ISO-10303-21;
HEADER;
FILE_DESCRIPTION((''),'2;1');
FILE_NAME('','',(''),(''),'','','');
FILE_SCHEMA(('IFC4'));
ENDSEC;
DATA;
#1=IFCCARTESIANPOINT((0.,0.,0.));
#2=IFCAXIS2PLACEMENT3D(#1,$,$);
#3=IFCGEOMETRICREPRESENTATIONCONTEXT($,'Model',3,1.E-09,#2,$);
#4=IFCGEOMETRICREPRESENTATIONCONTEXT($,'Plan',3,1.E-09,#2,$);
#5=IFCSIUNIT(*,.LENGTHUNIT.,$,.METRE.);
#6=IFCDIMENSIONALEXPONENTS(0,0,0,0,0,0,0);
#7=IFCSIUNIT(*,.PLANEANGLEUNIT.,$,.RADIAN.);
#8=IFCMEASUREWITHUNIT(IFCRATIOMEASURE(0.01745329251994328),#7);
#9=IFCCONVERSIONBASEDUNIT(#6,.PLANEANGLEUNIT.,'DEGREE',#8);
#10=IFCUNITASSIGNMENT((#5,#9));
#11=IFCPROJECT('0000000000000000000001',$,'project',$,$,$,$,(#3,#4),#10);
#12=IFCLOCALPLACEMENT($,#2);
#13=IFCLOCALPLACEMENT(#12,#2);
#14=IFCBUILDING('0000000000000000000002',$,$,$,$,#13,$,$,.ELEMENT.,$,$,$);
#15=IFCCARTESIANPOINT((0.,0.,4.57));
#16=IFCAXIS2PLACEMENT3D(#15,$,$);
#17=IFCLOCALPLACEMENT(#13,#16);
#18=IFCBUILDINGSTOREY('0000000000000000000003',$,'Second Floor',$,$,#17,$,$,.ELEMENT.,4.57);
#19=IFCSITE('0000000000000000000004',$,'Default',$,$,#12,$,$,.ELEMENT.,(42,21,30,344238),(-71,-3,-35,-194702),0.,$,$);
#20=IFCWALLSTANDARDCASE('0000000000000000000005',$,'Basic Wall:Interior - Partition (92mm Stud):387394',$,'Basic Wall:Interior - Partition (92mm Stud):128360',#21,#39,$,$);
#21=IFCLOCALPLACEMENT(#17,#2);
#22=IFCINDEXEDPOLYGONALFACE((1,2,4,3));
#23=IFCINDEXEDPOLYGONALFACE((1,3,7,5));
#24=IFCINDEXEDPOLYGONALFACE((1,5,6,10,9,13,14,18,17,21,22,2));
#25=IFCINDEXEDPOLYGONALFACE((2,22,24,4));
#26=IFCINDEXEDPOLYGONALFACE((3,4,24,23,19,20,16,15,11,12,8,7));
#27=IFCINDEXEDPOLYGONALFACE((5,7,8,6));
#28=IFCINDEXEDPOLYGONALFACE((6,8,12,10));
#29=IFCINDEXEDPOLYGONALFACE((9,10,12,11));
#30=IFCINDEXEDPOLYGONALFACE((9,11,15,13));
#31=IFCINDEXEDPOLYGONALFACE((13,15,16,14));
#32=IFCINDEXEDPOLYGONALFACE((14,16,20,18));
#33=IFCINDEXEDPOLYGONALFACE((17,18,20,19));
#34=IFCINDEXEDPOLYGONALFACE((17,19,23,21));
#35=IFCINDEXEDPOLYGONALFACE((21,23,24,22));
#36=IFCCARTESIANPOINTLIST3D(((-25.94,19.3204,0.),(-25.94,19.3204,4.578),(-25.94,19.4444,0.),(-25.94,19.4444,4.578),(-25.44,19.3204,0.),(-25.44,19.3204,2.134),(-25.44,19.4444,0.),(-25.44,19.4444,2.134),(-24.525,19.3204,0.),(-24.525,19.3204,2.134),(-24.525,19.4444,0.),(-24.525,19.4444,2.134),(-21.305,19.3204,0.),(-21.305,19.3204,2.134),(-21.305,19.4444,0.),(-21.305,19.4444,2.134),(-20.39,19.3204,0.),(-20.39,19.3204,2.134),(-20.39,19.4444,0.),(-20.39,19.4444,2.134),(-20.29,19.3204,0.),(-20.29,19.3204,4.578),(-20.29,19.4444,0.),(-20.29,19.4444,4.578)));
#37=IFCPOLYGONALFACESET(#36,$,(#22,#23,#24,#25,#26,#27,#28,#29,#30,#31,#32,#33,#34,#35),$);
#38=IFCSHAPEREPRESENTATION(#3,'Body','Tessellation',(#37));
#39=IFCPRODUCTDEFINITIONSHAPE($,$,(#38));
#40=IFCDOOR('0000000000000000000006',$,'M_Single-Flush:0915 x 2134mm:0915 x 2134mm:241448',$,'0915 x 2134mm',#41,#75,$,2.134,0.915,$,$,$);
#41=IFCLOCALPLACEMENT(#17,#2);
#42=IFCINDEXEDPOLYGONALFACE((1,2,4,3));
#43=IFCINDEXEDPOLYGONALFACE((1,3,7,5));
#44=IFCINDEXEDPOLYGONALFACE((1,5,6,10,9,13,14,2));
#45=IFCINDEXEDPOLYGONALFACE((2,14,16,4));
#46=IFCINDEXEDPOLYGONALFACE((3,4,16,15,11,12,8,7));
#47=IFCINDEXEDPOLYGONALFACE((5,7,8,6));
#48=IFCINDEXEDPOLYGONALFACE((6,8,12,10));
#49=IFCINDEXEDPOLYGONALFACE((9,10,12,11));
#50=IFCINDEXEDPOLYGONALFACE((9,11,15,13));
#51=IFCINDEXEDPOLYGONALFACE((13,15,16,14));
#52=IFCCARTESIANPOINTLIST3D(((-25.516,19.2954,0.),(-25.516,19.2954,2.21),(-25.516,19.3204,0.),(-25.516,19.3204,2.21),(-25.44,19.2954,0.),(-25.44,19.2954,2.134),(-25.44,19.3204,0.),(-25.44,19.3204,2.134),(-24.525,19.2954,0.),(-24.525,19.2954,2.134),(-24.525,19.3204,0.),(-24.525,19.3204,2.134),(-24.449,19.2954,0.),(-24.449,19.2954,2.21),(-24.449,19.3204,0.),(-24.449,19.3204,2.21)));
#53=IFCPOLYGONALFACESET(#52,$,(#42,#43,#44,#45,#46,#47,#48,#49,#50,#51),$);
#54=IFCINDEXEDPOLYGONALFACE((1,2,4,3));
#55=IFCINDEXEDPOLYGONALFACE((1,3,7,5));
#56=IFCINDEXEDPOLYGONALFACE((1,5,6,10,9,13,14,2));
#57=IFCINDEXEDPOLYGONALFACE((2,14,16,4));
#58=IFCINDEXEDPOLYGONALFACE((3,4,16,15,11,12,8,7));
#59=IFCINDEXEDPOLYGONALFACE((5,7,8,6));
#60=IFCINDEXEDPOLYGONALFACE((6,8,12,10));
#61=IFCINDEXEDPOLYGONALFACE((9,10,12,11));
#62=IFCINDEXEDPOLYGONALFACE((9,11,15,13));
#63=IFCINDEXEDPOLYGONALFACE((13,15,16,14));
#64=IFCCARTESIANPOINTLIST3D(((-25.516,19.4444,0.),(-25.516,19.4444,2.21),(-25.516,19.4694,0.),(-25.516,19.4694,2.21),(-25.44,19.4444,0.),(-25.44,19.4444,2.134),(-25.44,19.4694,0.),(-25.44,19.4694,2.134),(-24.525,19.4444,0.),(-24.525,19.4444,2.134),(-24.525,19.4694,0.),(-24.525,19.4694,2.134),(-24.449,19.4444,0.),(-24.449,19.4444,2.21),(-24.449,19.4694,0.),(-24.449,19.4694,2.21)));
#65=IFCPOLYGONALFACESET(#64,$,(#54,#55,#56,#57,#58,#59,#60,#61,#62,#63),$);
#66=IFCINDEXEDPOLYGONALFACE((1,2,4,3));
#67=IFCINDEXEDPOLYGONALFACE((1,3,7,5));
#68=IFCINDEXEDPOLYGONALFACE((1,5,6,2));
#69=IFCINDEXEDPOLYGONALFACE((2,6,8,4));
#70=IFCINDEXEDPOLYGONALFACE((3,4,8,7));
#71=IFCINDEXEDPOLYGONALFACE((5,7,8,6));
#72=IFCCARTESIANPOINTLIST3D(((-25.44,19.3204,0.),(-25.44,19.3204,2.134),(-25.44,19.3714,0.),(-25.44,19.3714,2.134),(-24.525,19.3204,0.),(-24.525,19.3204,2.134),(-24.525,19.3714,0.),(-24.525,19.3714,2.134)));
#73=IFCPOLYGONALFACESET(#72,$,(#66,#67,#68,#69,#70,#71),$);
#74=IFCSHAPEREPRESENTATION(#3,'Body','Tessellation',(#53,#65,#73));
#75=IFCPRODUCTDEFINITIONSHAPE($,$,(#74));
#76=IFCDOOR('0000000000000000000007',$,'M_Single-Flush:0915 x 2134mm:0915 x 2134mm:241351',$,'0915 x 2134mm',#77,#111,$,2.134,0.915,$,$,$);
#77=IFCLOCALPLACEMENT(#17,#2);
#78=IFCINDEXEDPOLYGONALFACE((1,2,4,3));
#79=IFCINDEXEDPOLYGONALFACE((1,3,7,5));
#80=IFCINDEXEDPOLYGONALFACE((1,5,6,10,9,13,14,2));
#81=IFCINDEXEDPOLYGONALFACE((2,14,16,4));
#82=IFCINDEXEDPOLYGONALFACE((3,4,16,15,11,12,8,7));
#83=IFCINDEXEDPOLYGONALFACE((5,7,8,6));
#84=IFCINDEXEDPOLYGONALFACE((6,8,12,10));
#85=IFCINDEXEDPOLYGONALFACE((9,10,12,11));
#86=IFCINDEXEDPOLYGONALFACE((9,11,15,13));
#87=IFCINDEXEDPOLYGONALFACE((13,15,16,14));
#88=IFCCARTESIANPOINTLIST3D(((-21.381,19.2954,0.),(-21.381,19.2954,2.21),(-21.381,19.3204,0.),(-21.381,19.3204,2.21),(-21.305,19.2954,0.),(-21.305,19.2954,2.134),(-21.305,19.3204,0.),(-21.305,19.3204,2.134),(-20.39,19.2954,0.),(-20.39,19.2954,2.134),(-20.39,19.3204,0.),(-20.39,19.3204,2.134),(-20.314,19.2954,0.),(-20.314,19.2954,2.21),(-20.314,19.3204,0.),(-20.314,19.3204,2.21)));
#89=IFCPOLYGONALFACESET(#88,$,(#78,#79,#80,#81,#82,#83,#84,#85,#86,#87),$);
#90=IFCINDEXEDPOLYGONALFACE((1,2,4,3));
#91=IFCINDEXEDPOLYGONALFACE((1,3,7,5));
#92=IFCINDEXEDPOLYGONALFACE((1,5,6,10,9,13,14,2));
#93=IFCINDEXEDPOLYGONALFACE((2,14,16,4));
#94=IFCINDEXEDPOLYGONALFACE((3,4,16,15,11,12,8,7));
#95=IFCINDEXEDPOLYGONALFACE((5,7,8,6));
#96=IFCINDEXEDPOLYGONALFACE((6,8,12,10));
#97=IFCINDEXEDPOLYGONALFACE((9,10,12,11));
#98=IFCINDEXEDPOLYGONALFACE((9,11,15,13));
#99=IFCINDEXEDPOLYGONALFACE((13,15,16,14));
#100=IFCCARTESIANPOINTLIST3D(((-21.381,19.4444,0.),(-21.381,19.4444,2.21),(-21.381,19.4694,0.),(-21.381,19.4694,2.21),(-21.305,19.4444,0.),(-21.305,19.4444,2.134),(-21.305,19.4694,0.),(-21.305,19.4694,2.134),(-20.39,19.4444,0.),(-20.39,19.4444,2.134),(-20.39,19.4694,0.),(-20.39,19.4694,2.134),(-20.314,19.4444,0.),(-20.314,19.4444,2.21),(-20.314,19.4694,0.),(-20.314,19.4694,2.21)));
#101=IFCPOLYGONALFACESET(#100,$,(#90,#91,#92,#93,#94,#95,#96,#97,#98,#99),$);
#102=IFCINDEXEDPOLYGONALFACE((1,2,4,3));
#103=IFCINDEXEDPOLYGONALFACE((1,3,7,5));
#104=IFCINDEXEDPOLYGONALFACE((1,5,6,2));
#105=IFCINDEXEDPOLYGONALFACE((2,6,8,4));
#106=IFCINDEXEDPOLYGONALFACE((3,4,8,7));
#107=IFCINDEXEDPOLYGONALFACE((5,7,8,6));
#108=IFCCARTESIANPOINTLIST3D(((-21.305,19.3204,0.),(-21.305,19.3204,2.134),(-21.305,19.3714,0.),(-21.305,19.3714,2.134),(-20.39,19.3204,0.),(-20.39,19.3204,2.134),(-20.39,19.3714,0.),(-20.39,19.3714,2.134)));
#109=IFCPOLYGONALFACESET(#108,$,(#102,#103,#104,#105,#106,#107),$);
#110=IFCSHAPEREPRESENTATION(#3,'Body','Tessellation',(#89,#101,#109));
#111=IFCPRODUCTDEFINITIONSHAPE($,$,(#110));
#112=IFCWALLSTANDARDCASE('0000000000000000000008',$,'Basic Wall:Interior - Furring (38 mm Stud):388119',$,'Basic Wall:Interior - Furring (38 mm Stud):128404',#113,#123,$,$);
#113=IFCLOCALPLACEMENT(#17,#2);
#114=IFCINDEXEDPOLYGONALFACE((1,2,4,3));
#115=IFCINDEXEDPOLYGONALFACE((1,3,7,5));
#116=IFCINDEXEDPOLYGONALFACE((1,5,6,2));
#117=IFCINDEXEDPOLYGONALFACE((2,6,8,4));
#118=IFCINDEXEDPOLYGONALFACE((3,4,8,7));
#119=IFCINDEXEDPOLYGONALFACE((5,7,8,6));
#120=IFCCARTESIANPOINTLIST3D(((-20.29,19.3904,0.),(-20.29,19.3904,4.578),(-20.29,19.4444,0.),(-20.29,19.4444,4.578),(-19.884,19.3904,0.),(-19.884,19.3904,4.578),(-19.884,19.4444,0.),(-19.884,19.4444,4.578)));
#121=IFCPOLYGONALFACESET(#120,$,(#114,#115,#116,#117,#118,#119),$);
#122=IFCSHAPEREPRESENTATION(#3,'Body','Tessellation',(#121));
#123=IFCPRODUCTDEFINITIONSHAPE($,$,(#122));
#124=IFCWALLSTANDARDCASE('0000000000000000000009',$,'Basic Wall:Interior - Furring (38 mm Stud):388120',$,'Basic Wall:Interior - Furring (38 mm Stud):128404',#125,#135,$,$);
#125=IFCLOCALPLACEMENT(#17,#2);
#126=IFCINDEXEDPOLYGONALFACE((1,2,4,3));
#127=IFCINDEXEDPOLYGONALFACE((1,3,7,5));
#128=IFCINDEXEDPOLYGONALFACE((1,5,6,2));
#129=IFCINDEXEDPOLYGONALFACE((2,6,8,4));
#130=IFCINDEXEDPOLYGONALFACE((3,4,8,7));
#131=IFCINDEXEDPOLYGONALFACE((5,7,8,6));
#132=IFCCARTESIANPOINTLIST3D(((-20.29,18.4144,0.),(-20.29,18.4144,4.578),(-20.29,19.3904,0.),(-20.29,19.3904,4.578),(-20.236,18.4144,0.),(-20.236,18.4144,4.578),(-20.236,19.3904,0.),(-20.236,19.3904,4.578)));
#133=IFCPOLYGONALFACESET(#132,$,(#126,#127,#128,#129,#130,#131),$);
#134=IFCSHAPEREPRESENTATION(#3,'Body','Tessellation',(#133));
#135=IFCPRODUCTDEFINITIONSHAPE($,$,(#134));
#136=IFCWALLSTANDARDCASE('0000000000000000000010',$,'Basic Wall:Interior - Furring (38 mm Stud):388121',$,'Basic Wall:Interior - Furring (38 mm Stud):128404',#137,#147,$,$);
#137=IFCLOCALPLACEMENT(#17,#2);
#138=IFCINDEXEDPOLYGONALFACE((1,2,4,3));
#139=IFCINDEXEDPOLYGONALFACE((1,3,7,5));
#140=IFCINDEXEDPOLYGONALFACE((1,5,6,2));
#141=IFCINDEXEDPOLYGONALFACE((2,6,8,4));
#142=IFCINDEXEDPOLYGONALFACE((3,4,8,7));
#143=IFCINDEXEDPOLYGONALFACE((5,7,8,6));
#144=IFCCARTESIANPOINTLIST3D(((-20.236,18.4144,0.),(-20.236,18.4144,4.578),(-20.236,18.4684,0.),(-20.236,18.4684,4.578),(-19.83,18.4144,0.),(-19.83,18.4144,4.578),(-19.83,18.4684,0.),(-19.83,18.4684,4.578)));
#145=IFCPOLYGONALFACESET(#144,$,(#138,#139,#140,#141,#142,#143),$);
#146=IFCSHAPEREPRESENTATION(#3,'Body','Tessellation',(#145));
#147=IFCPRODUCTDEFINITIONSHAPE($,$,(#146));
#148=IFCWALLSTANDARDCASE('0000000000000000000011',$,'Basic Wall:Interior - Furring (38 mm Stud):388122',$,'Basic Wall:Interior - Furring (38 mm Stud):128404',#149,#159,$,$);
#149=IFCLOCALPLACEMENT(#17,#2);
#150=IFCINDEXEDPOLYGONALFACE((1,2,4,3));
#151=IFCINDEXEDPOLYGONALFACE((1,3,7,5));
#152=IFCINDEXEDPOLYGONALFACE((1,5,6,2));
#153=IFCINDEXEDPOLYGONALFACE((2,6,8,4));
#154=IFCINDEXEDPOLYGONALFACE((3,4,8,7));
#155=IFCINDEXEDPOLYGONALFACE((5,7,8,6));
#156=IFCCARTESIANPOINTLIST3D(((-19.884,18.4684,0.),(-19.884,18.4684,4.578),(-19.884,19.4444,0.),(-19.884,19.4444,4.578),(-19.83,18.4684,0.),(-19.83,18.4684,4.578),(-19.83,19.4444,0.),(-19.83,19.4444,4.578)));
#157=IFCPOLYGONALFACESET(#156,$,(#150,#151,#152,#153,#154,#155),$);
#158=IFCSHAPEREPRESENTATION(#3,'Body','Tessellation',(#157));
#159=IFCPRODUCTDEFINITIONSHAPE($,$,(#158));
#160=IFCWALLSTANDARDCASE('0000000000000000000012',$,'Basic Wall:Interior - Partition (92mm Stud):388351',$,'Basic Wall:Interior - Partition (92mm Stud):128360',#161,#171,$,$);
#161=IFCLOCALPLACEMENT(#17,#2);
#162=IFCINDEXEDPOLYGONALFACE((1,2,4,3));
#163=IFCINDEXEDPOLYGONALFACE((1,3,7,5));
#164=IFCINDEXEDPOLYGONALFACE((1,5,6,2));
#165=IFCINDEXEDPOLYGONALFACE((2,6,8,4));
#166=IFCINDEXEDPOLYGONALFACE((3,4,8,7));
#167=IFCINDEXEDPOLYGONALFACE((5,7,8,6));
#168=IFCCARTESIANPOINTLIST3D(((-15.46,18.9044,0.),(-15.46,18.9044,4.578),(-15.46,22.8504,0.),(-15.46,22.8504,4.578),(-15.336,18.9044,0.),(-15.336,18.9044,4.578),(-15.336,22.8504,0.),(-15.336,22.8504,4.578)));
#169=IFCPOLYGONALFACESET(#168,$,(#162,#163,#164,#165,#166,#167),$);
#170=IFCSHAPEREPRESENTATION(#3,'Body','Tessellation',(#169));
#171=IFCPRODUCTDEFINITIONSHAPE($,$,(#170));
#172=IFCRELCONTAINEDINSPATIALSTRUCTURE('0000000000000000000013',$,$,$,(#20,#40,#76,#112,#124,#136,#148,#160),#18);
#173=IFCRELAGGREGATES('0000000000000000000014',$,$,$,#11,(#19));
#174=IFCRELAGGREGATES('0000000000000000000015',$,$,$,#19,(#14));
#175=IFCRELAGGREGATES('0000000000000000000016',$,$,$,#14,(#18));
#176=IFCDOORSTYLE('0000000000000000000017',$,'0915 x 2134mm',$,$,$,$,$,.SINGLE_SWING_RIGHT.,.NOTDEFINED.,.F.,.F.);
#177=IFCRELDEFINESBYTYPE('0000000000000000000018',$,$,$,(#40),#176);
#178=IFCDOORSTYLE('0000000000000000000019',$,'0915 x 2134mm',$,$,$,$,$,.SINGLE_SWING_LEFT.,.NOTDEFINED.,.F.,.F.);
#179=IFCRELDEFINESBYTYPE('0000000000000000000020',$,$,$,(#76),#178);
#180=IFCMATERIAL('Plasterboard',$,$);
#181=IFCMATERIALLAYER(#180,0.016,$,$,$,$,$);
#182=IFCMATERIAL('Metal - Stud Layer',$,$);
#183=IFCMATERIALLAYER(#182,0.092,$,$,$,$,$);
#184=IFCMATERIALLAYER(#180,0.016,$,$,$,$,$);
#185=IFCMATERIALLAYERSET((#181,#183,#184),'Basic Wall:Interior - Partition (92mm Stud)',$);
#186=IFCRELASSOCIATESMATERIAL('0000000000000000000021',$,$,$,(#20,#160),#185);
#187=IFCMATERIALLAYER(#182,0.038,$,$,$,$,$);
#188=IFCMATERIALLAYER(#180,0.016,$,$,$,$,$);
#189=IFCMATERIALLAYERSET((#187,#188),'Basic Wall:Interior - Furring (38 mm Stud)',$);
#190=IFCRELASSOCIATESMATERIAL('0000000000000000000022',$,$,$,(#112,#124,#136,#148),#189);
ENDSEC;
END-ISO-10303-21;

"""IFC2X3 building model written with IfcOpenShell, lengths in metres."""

from ifc_helpers import new_model, entity, si_unit, converted_unit, frame, frame_2d, origin, origin_2d_with_axis, place, context, project, spatial, polyline, rectangle, outline, extrude, source, transform, mapped, material, layer, layer_set, layer_usage, type_object, type_shapes, element, fill, save


model = new_model("IFC2X3")

# Units and contexts
model_context = context("Model", 3, precision=1e-09, world=origin())
plan_context = context("Plan", 3, precision=1e-09, world=origin())
ifc_project = project(units=[si_unit("LENGTHUNIT", "METRE"), converted_unit("PLANEANGLEUNIT", "DEGREE", entity("IfcRatioMeasure", 0.01745329251994328), si_unit("PLANEANGLEUNIT", "RADIAN"), dimensions=[0, 0, 0, 0, 0, 0, 0])], contexts=[model_context, plan_context])

# Site, building, storey
site_placement = place(None, origin())
site = spatial("IfcSite", under=ifc_project, at=site_placement, Name="Default", CompositionType="ELEMENT", RefLatitude=(42, 21, 30, 344238), RefLongitude=(-71, -3, -35, -194702), RefElevation=0.0)
building_placement = place(site_placement, origin())
building = spatial("IfcBuilding", under=site, at=building_placement, CompositionType="ELEMENT")
storey_placement = place(building_placement, frame((0.0, 0.0, 4.57)))
storey = spatial("IfcBuildingStorey", under=building, at=storey_placement, Name="Second Floor", CompositionType="ELEMENT", Elevation=4.57)

# Shared definitions
ifc_material_1 = material(Name="Plasterboard")
ifc_layer_1 = layer(ifc_material_1, 0.016)
ifc_material_2 = material(Name="Metal - Stud Layer")
ifc_layer_2 = layer(ifc_material_2, 0.092)
ifc_layer_3 = layer(ifc_material_1, 0.016)
ifc_layer_set_1 = layer_set([ifc_layer_1, ifc_layer_2, ifc_layer_3], Name="Basic Wall:Interior - Partition (92mm Stud)")
door_style_1 = type_object("IfcDoorStyle", Name="0915 x 2134mm", ConstructionType="NOTDEFINED", OperationType="SINGLE_SWING_RIGHT", ParameterTakesPrecedence=False, Sizeable=False)
shared_shape_1 = source(origin(), model_context, "Body", "SweptSolid", [
    extrude(outline(polyline([(-0.5335, -1.124), (0.5335, -1.124), (0.5335, 1.086), (0.4575, 1.086), (0.4575, -1.048), (-0.4575, -1.048), (-0.4575, 1.086), (-0.5335, 1.086), (-0.5335, -1.124)])), frame((0.4575, 0.124, 1.086), z_axis=(0.0, 1.0, 0.0), x_axis=(1.0, 0.0, 0.0)), (0.0, 0.0, 1.0), 0.025),
    extrude(outline(polyline([(-1.124, -0.5335), (1.086, -0.5335), (1.086, -0.4575), (-1.048, -0.4575), (-1.048, 0.4575), (1.086, 0.4575), (1.086, 0.5335), (-1.124, 0.5335), (-1.124, -0.5335)])), frame((0.4575, -0.025, 1.086), z_axis=(0.0, 1.0, 0.0), x_axis=(0.0, 0.0, -1.0)), (0.0, 0.0, 1.0), 0.025),
    extrude(rectangle(XDim=0.051, YDim=0.915, at=origin_2d_with_axis()), frame((0.4575, 0.0985, 0.0), z_axis=(0.0, 0.0, 1.0), x_axis=(0.0, 1.0, 0.0)), (0.0, 0.0, 1.0), 2.134),
])
type_shapes(door_style_1, [shared_shape_1])
door_style_2 = type_object("IfcDoorStyle", Name="0915 x 2134mm", ConstructionType="NOTDEFINED", OperationType="SINGLE_SWING_LEFT", ParameterTakesPrecedence=False, Sizeable=False)
shared_shape_2 = source(origin(), model_context, "Body", "SweptSolid", [
    extrude(outline(polyline([(-0.5335, -1.124), (0.5335, -1.124), (0.5335, 1.086), (0.4575, 1.086), (0.4575, -1.048), (-0.4575, -1.048), (-0.4575, 1.086), (-0.5335, 1.086), (-0.5335, -1.124)])), frame((0.4575, 0.149, 1.086), z_axis=(0.0, -1.0, 0.0), x_axis=(-1.0, 0.0, 0.0)), (0.0, 0.0, 1.0), 0.025),
    extrude(outline(polyline([(-1.124, -0.5335), (1.086, -0.5335), (1.086, -0.4575), (-1.048, -0.4575), (-1.048, 0.4575), (1.086, 0.4575), (1.086, 0.5335), (-1.124, 0.5335), (-1.124, -0.5335)])), frame((0.4575, 0.0, 1.086), z_axis=(0.0, -1.0, 0.0), x_axis=(0.0, 0.0, -1.0)), (0.0, 0.0, 1.0), 0.025),
    extrude(rectangle(XDim=0.915, YDim=0.051, at=origin_2d_with_axis()), frame((0.4575, 0.0985, 0.0)), (0.0, 0.0, 1.0), 2.134),
])
type_shapes(door_style_2, [shared_shape_2])

# Shared definitions
ifc_layer_4 = layer(ifc_material_2, 0.038)
ifc_layer_5 = layer(ifc_material_1, 0.016)
ifc_layer_set_2 = layer_set([ifc_layer_4, ifc_layer_5], Name="Basic Wall:Interior - Furring (38 mm Stud)")

# Wall, openings, doors
ifc_layer_usage_1 = layer_usage(ifc_layer_set_1, "AXIS2", "NEGATIVE", 0.062)
wall_1_placement = place(storey_placement, frame((-25.94, 19.3824, 0.0)))
wall_1 = element("IfcWallStandardCase", 1, at=wall_1_placement, inside=storey, material=ifc_layer_usage_1, Name="Basic Wall:Interior - Partition (92mm Stud):387394", ObjectType="Basic Wall:Interior - Partition (92mm Stud):128360", context=model_context, shape_type="SweptSolid", body=[
    extrude(rectangle(XDim=5.65, YDim=0.124, at=frame_2d((2.825, 0.0), x_axis=(-1.0, 0.0))), origin(), (0.0, 0.0, 1.0), 4.578),
])
opening_1_placement = place(wall_1_placement, frame((5.55, 0.062, 0.0)))
opening_1 = element("IfcOpeningElement", 2, at=opening_1_placement, cuts=wall_1, ObjectType="Opening", context=model_context, shape_type="SweptSolid", body=[
    extrude(rectangle(XDim=0.915, YDim=2.134, at=frame_2d((1.067, 0.4575), x_axis=(0.0, -1.0))), frame((0.0, 0.0, 0.0), z_axis=(0.0, -1.0, 0.0), x_axis=(0.0, 0.0, 1.0)), (0.0, 0.0, 1.0), 0.124),
])
opening_2_placement = place(wall_1_placement, frame((1.415, 0.062, 0.0)))
opening_2 = element("IfcOpeningElement", 3, at=opening_2_placement, cuts=wall_1, ObjectType="Opening", context=model_context, shape_type="SweptSolid", body=[
    extrude(rectangle(XDim=0.915, YDim=2.134, at=frame_2d((1.067, 0.4575), x_axis=(0.0, 1.0))), frame((0.0, 0.0, 0.0), z_axis=(0.0, -1.0, 0.0), x_axis=(0.0, 0.0, 1.0)), (0.0, 0.0, 1.0), 0.124),
])
door_1_placement = place(opening_2_placement, frame((0.0, 0.0, 0.0), z_axis=(0.0, 0.0, 1.0), x_axis=(-1.0, 0.0, 0.0)))
door_1 = element("IfcDoor", 4, at=door_1_placement, inside=storey, type_object=door_style_1, Name="M_Single-Flush:0915 x 2134mm:0915 x 2134mm:241448", ObjectType="0915 x 2134mm", OverallHeight=2.134, OverallWidth=0.915, context=model_context, shape_type="MappedRepresentation", body=[
    mapped(shared_shape_1, transform((0.0, 0.0, 0.0), scale=1.0)),
])
fill(opening_2, door_1)
door_2_placement = place(opening_1_placement, frame((0.0, 0.0, 0.0), z_axis=(0.0, 0.0, 1.0), x_axis=(-1.0, 0.0, 0.0)))
door_2 = element("IfcDoor", 5, at=door_2_placement, inside=storey, type_object=door_style_2, Name="M_Single-Flush:0915 x 2134mm:0915 x 2134mm:241351", ObjectType="0915 x 2134mm", OverallHeight=2.134, OverallWidth=0.915, context=model_context, shape_type="MappedRepresentation", body=[
    mapped(shared_shape_2, transform((0.0, 0.0, 0.0), scale=1.0)),
])
fill(opening_1, door_2)

# Walls
ifc_layer_usage_2 = layer_usage(ifc_layer_set_2, "AXIS2", "POSITIVE", -0.027)
wall_2_placement = place(storey_placement, frame((-20.29, 19.4174, 0.0)))
element("IfcWallStandardCase", 6, at=wall_2_placement, inside=storey, material=ifc_layer_usage_2, Name="Basic Wall:Interior - Furring (38 mm Stud):388119", ObjectType="Basic Wall:Interior - Furring (38 mm Stud):128404", context=model_context, shape_type="SweptSolid", body=[
    extrude(rectangle(XDim=0.406, YDim=0.054, at=frame_2d((0.203, 0.0), x_axis=(-1.0, 0.0))), origin(), (0.0, 0.0, 1.0), 4.578),
])
ifc_layer_usage_3 = layer_usage(ifc_layer_set_2, "AXIS2", "POSITIVE", -0.027)
wall_3_placement = place(storey_placement, frame((-20.263, 18.4144, 0.0), z_axis=(0.0, 0.0, 1.0), x_axis=(0.0, 1.0, 0.0)))
element("IfcWallStandardCase", 7, at=wall_3_placement, inside=storey, material=ifc_layer_usage_3, Name="Basic Wall:Interior - Furring (38 mm Stud):388120", ObjectType="Basic Wall:Interior - Furring (38 mm Stud):128404", context=model_context, shape_type="SweptSolid", body=[
    extrude(rectangle(XDim=0.976, YDim=0.054, at=frame_2d((0.488, 0.0), x_axis=(-1.0, 0.0))), origin(), (0.0, 0.0, 1.0), 4.578),
])
ifc_layer_usage_4 = layer_usage(ifc_layer_set_2, "AXIS2", "POSITIVE", -0.027)
wall_4_placement = place(storey_placement, frame((-19.83, 18.4414, 0.0), z_axis=(0.0, 0.0, 1.0), x_axis=(-1.0, 0.0, 0.0)))
element("IfcWallStandardCase", 8, at=wall_4_placement, inside=storey, material=ifc_layer_usage_4, Name="Basic Wall:Interior - Furring (38 mm Stud):388121", ObjectType="Basic Wall:Interior - Furring (38 mm Stud):128404", context=model_context, shape_type="SweptSolid", body=[
    extrude(rectangle(XDim=0.406, YDim=0.054, at=frame_2d((0.203, 0.0), x_axis=(-1.0, 0.0))), origin(), (0.0, 0.0, 1.0), 4.578),
])
ifc_layer_usage_5 = layer_usage(ifc_layer_set_2, "AXIS2", "POSITIVE", -0.027)
wall_5_placement = place(storey_placement, frame((-19.857, 19.4444, 0.0), z_axis=(0.0, 0.0, 1.0), x_axis=(0.0, -1.0, 0.0)))
element("IfcWallStandardCase", 9, at=wall_5_placement, inside=storey, material=ifc_layer_usage_5, Name="Basic Wall:Interior - Furring (38 mm Stud):388122", ObjectType="Basic Wall:Interior - Furring (38 mm Stud):128404", context=model_context, shape_type="SweptSolid", body=[
    extrude(rectangle(XDim=0.976, YDim=0.054, at=frame_2d((0.488, 0.0), x_axis=(-1.0, 0.0))), origin(), (0.0, 0.0, 1.0), 4.578),
])
ifc_layer_usage_6 = layer_usage(ifc_layer_set_1, "AXIS2", "NEGATIVE", 0.062)
wall_6_placement = place(storey_placement, frame((-15.398, 18.9044, 0.0), z_axis=(0.0, 0.0, 1.0), x_axis=(0.0, 1.0, 0.0)))
element("IfcWallStandardCase", 10, at=wall_6_placement, inside=storey, material=ifc_layer_usage_6, Name="Basic Wall:Interior - Partition (92mm Stud):388351", ObjectType="Basic Wall:Interior - Partition (92mm Stud):128360", context=model_context, shape_type="SweptSolid", body=[
    extrude(rectangle(XDim=3.946, YDim=0.124, at=frame_2d((1.973, 0.0), x_axis=(-1.0, 0.0))), origin(), (0.0, 0.0, 1.0), 4.578),
])

save(model, "model.ifc")
